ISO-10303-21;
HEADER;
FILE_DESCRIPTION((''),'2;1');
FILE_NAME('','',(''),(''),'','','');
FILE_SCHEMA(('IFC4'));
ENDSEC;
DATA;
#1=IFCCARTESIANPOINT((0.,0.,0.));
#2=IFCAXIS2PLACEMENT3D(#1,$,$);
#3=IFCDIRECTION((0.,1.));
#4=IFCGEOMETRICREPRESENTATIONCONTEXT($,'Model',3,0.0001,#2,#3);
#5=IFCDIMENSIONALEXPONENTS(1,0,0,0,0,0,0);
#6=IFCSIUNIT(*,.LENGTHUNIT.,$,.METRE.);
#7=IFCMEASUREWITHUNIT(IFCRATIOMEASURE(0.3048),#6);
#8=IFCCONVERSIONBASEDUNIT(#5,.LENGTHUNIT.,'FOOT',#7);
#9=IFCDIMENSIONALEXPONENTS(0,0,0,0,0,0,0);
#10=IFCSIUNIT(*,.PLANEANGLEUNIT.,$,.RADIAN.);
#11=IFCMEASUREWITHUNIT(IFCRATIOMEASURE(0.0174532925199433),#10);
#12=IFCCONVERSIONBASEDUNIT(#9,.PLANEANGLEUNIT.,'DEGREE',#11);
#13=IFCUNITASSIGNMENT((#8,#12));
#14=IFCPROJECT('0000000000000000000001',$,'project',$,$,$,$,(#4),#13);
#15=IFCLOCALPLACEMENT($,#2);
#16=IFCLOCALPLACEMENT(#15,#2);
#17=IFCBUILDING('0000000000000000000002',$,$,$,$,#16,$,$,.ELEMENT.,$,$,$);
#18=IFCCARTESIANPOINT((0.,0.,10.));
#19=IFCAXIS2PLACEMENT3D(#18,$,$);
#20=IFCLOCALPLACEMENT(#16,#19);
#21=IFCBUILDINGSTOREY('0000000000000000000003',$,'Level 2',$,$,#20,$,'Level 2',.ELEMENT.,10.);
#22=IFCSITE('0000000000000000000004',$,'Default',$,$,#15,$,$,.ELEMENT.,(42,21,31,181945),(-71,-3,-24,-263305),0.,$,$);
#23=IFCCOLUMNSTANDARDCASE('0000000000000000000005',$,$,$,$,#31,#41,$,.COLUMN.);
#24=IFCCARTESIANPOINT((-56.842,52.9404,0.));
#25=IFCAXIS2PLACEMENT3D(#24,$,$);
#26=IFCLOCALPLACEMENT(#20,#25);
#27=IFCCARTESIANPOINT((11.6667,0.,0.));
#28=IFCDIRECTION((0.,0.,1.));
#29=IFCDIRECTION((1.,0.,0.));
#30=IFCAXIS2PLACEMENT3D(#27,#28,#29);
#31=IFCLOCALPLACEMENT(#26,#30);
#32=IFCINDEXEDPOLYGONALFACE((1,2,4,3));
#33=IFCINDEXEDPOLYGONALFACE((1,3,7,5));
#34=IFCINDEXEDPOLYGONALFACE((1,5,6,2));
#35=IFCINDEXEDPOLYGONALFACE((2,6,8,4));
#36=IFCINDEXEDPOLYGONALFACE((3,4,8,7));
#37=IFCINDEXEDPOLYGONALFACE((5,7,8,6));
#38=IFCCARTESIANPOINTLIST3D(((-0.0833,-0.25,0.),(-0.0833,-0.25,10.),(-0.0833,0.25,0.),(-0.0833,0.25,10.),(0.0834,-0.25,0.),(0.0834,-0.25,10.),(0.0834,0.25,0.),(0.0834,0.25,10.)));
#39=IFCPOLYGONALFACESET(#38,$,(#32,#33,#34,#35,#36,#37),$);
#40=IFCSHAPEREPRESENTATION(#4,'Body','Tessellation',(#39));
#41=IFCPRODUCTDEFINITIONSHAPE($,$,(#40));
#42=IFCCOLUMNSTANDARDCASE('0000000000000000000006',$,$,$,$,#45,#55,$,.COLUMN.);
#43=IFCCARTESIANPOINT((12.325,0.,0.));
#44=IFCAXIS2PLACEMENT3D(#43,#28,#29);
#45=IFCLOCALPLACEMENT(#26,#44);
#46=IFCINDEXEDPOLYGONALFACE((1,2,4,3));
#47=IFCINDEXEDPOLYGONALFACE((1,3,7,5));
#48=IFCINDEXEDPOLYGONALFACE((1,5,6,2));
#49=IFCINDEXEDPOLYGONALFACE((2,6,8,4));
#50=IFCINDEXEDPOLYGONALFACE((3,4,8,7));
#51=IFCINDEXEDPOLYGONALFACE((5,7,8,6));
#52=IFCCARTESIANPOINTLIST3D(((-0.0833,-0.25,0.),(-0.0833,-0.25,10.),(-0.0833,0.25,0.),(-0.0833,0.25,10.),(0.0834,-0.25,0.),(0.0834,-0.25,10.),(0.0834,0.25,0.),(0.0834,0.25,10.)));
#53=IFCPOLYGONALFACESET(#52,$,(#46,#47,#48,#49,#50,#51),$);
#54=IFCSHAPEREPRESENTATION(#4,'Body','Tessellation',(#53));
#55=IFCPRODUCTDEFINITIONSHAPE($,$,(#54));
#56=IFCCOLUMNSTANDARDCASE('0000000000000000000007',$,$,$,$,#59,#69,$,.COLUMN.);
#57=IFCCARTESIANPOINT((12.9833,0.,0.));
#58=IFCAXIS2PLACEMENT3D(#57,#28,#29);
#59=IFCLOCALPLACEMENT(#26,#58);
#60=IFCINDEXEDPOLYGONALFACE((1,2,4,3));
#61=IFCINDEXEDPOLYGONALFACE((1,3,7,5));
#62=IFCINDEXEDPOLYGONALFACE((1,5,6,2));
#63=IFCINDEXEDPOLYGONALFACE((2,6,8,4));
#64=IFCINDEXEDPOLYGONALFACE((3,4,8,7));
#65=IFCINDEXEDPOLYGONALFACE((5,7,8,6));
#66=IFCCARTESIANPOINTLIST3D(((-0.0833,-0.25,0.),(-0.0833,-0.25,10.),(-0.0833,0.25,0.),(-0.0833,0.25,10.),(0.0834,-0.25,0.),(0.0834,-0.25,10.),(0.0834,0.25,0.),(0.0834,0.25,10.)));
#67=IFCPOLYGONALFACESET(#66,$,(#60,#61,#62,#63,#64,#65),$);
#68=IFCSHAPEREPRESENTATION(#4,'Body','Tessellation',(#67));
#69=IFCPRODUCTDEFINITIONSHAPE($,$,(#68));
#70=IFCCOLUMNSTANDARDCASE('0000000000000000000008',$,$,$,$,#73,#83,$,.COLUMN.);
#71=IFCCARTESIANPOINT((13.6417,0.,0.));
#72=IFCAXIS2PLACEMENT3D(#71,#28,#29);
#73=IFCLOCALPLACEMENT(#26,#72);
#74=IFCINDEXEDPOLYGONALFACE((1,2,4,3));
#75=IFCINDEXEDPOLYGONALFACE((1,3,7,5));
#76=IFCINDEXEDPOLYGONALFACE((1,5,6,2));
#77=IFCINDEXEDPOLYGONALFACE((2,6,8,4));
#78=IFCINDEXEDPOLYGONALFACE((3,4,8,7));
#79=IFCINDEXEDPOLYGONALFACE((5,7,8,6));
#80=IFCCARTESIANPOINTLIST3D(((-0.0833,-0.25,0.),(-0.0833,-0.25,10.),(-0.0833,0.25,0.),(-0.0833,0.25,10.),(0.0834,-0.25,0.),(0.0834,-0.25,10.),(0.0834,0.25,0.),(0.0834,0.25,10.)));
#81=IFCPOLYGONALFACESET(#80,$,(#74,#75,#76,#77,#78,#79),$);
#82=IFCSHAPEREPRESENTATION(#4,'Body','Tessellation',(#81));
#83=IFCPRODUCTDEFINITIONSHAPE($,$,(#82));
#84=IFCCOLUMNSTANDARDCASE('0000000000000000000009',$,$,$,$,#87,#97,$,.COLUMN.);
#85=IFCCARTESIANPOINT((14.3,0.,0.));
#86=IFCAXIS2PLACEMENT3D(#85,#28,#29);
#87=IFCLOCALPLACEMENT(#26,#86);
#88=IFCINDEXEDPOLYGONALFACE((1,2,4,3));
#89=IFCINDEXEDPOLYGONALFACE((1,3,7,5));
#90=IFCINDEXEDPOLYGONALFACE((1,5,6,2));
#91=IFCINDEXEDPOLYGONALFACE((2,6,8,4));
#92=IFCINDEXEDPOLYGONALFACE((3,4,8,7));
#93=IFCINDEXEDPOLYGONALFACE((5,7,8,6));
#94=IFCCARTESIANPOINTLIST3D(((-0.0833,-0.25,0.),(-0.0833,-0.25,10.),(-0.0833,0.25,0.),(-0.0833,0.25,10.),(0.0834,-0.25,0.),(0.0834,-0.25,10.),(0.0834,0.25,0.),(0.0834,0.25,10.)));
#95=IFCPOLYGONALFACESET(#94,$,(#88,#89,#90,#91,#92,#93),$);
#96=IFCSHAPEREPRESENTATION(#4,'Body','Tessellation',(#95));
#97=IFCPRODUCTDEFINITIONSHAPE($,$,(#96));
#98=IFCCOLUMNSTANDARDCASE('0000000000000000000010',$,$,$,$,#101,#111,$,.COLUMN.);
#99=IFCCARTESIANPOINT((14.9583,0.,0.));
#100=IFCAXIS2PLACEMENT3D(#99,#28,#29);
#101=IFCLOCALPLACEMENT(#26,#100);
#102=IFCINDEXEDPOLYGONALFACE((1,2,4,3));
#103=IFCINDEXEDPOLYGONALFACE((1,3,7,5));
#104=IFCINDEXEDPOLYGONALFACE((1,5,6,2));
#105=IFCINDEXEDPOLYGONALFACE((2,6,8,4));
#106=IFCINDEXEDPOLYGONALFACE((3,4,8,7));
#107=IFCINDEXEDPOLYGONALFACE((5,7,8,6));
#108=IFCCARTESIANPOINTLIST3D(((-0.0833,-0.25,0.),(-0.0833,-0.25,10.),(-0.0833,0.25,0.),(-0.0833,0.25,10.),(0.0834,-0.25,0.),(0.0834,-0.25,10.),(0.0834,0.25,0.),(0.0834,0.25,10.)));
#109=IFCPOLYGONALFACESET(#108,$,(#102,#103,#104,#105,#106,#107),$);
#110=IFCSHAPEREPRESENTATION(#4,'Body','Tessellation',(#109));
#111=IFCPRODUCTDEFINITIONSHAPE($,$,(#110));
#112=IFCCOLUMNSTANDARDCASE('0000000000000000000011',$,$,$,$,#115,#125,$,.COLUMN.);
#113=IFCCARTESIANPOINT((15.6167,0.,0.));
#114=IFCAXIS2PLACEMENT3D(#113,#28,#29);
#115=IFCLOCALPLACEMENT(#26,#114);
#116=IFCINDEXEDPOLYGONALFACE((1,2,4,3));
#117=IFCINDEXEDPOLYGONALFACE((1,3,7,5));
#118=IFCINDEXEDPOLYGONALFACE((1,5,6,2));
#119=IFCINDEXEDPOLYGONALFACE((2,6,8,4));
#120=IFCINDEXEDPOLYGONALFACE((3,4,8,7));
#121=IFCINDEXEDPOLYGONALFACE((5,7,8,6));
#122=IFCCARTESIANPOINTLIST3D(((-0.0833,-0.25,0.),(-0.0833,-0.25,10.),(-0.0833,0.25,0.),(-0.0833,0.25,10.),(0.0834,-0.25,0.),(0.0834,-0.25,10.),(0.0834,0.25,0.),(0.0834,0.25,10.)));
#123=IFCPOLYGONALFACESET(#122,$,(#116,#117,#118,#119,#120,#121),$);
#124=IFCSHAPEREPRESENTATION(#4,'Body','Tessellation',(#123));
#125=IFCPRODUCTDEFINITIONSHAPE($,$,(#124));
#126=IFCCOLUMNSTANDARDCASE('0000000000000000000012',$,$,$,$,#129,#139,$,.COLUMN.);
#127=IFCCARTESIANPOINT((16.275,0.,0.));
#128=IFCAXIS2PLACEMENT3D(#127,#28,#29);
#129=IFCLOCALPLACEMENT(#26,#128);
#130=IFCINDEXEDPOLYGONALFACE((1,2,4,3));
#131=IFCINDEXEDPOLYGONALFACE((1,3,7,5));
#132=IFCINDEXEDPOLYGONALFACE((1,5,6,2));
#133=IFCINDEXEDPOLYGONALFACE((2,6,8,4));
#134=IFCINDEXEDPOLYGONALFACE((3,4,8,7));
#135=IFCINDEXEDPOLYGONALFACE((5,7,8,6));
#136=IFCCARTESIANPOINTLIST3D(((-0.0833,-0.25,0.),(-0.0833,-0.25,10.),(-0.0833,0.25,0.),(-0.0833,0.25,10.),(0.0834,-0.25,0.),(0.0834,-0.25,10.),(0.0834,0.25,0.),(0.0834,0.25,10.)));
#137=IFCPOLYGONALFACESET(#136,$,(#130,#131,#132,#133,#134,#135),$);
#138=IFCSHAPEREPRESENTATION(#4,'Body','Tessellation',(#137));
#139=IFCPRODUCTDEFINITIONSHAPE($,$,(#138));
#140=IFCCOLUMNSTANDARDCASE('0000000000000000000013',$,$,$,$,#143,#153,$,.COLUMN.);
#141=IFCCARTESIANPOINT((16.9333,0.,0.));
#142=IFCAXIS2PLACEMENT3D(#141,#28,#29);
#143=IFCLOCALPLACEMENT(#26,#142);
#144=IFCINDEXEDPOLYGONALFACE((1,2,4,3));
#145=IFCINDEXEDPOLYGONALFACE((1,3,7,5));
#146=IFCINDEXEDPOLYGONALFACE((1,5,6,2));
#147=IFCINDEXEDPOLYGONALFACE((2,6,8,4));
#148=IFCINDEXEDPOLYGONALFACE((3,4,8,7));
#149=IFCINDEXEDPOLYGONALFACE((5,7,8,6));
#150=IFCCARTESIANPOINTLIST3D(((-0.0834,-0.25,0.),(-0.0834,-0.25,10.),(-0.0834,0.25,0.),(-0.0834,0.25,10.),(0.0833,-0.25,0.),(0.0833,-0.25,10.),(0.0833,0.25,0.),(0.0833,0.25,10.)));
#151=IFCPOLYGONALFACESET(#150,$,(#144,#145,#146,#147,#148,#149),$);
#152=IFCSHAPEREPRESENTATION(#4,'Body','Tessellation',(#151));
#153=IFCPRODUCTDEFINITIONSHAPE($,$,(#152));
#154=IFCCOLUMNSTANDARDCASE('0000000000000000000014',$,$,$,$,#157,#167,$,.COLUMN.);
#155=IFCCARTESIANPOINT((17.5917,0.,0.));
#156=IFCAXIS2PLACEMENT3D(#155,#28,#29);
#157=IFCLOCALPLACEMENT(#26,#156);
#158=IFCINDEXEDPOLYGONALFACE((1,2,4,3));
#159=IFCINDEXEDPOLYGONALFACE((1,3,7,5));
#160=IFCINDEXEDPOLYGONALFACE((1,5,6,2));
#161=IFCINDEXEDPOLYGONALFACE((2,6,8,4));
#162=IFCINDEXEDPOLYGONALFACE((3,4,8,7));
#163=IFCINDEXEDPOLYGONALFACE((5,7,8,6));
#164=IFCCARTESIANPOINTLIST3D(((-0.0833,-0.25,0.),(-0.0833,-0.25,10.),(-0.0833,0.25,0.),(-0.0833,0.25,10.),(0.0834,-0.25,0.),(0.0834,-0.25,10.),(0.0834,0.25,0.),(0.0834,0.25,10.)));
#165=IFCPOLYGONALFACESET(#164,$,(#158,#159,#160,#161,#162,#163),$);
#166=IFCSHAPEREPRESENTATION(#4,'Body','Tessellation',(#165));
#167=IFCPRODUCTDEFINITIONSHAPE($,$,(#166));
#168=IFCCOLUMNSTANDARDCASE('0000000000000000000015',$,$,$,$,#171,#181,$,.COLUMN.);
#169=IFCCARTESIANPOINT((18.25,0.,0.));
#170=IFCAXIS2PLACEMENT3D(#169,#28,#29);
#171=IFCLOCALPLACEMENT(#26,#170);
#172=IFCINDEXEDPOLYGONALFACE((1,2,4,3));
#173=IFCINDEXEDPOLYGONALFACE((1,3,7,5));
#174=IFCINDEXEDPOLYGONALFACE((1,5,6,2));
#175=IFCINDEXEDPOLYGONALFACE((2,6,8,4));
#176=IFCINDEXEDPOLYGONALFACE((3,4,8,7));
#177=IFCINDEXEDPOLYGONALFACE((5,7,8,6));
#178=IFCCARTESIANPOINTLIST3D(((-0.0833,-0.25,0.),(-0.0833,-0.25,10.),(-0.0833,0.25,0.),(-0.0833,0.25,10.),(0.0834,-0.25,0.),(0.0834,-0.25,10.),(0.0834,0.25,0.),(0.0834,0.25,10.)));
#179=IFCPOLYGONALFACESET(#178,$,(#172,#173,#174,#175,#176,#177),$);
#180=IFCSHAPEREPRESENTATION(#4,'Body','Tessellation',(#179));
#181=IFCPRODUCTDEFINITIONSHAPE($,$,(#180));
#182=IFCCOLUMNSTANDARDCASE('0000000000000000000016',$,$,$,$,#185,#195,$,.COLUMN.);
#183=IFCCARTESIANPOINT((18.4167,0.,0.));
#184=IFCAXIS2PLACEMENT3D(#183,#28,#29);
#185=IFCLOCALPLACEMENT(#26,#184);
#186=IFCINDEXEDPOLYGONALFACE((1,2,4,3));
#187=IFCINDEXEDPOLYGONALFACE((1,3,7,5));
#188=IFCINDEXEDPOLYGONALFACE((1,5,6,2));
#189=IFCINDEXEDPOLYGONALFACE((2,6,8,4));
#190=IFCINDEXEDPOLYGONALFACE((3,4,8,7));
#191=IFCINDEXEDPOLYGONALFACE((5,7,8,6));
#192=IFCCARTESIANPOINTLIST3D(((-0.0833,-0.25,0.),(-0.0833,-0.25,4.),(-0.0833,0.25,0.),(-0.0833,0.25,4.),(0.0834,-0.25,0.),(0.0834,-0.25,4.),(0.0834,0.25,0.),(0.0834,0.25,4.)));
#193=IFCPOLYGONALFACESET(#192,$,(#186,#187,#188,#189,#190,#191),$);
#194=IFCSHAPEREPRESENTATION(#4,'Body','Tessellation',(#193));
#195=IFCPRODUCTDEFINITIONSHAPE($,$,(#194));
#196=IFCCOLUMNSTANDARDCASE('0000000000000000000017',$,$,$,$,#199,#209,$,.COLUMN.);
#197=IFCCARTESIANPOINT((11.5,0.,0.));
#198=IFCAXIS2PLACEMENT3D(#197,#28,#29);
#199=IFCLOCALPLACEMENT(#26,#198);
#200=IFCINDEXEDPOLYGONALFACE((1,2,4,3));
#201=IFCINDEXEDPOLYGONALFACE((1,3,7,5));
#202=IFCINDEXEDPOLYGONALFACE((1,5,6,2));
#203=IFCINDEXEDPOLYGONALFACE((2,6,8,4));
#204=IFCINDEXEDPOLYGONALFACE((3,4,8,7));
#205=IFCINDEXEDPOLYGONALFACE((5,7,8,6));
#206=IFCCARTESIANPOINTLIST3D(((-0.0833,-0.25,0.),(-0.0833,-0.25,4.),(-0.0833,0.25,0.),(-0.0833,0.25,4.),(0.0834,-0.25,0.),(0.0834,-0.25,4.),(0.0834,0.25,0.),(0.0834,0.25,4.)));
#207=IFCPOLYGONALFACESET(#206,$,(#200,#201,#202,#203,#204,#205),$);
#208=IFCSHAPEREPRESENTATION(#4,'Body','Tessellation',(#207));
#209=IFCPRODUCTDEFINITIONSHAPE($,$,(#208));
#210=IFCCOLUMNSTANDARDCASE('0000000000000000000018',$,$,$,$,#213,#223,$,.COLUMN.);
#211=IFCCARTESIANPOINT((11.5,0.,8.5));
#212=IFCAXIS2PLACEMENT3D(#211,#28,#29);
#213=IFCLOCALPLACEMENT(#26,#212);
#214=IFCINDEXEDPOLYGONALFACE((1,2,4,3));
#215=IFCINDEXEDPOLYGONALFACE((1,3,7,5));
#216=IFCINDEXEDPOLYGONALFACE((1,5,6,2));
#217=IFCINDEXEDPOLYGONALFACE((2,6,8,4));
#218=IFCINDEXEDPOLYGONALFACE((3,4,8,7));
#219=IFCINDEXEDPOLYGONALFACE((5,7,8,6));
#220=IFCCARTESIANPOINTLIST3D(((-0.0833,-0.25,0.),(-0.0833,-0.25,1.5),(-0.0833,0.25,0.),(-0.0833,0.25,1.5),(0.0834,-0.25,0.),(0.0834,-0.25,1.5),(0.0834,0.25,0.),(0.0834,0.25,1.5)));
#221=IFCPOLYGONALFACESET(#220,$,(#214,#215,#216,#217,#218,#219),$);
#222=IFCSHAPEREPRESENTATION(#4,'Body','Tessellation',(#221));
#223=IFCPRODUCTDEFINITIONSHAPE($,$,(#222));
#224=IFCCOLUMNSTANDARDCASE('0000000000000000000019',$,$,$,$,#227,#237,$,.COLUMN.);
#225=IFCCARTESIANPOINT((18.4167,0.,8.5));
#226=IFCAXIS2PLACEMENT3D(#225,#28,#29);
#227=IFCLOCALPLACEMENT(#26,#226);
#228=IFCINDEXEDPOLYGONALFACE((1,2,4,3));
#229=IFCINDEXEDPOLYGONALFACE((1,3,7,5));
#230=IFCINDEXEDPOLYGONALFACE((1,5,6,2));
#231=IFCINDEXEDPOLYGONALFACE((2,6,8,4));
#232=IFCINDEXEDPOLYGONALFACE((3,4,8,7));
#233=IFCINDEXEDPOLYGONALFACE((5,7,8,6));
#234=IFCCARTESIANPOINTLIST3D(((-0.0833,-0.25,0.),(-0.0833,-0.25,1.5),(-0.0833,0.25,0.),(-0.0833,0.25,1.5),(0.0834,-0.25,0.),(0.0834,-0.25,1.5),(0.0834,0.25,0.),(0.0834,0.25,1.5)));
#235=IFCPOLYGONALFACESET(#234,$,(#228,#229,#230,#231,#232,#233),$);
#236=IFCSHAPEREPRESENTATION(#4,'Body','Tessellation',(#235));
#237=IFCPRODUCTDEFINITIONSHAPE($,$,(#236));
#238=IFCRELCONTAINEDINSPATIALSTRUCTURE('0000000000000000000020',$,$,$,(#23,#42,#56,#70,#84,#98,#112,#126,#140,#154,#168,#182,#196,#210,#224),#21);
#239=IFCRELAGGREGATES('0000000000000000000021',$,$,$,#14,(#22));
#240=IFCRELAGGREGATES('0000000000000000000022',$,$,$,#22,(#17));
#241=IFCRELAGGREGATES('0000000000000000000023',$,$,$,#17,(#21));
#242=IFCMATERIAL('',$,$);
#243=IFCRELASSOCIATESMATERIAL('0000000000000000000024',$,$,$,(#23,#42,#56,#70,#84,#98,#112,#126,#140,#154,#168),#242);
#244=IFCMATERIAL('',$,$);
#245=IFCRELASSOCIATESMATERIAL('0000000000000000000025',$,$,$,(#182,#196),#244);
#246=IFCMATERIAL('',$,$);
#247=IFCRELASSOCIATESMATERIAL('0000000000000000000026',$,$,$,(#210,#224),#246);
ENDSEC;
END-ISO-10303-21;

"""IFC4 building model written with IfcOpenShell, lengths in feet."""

from ifc_helpers import new_model, entity, si_unit, converted_unit, direction, frame, origin, place, context, project, spatial, rectangle, extrude, material, element, save


model = new_model("IFC4")

# Units and contexts
model_context = context("Model", 3, precision=0.0001, world=origin(), true_north=direction((0.0, 1.0)))
ifc_project = project(units=[converted_unit("LENGTHUNIT", "FOOT", entity("IfcRatioMeasure", 0.3048), si_unit("LENGTHUNIT", "METRE"), dimensions=[1, 0, 0, 0, 0, 0, 0]), converted_unit("PLANEANGLEUNIT", "DEGREE", entity("IfcRatioMeasure", 0.0174532925199433), si_unit("PLANEANGLEUNIT", "RADIAN"), dimensions=[0, 0, 0, 0, 0, 0, 0])], contexts=[model_context])

# Site, building, storey
site_placement = place(None, origin())
site = spatial("IfcSite", under=ifc_project, at=site_placement, Name="Default", CompositionType="ELEMENT", RefLatitude=(42, 21, 31, 181945), RefLongitude=(-71, -3, -24, -263305), RefElevation=0.0)
building_placement = place(site_placement, origin())
building = spatial("IfcBuilding", under=site, at=building_placement, CompositionType="ELEMENT")
storey_placement = place(building_placement, frame((0.0, 0.0, 10.0)))
storey = spatial("IfcBuildingStorey", under=building, at=storey_placement, Name="Level 2", LongName="Level 2", CompositionType="ELEMENT", Elevation=10.0)

# Columns
ifc_material_1 = material(Name="")
placement = place(storey_placement, frame((-56.842, 52.9404, 0.0)))
for number, where, z_axis, x_axis in (
    (1, (11.6667, 0.0, 0.0), (0.0, 0.0, 1.0), (1.0, 0.0, 0.0)),
    (2, (12.325, 0.0, 0.0), (0.0, 0.0, 1.0), (1.0, 0.0, 0.0)),
    (3, (12.9833, 0.0, 0.0), (0.0, 0.0, 1.0), (1.0, 0.0, 0.0)),
    (4, (13.6417, 0.0, 0.0), (0.0, 0.0, 1.0), (1.0, 0.0, 0.0)),
    (5, (14.3, 0.0, 0.0), (0.0, 0.0, 1.0), (1.0, 0.0, 0.0)),
    (6, (14.9583, 0.0, 0.0), (0.0, 0.0, 1.0), (1.0, 0.0, 0.0)),
    (7, (15.6167, 0.0, 0.0), (0.0, 0.0, 1.0), (1.0, 0.0, 0.0)),
    (8, (16.275, 0.0, 0.0), (0.0, 0.0, 1.0), (1.0, 0.0, 0.0)),
    (9, (16.9333, 0.0, 0.0), (0.0, 0.0, 1.0), (1.0, 0.0, 0.0)),
    (10, (17.5917, 0.0, 0.0), (0.0, 0.0, 1.0), (1.0, 0.0, 0.0)),
    (11, (18.25, 0.0, 0.0), (0.0, 0.0, 1.0), (1.0, 0.0, 0.0)),
):
    element("IfcColumnStandardCase", number, at=place(placement, frame(where, z_axis=z_axis, x_axis=x_axis)), inside=storey, material=ifc_material_1, PredefinedType="COLUMN", context=model_context, shape_type="SweptSolid", body=[
        extrude(rectangle(XDim=0.1667, YDim=0.5), origin(), (0.0, 0.0, 1.0), 10.0),
    ])
ifc_material_2 = material(Name="")
for number, where, z_axis, x_axis in (
    (12, (18.4167, 0.0, 0.0), (0.0, 0.0, 1.0), (1.0, 0.0, 0.0)),
    (13, (11.5, 0.0, 0.0), (0.0, 0.0, 1.0), (1.0, 0.0, 0.0)),
):
    element("IfcColumnStandardCase", number, at=place(placement, frame(where, z_axis=z_axis, x_axis=x_axis)), inside=storey, material=ifc_material_2, PredefinedType="COLUMN", context=model_context, shape_type="SweptSolid", body=[
        extrude(rectangle(XDim=0.1667, YDim=0.5), origin(), (0.0, 0.0, 1.0), 4.0),
    ])
ifc_material_3 = material(Name="")
for number, where, z_axis, x_axis in (
    (14, (11.5, 0.0, 8.5), (0.0, 0.0, 1.0), (1.0, 0.0, 0.0)),
    (15, (18.4167, 0.0, 8.5), (0.0, 0.0, 1.0), (1.0, 0.0, 0.0)),
):
    element("IfcColumnStandardCase", number, at=place(placement, frame(where, z_axis=z_axis, x_axis=x_axis)), inside=storey, material=ifc_material_3, PredefinedType="COLUMN", context=model_context, shape_type="SweptSolid", body=[
        extrude(rectangle(XDim=0.1667, YDim=0.5), origin(), (0.0, 0.0, 1.0), 1.5),
    ])

save(model, "model.ifc")
